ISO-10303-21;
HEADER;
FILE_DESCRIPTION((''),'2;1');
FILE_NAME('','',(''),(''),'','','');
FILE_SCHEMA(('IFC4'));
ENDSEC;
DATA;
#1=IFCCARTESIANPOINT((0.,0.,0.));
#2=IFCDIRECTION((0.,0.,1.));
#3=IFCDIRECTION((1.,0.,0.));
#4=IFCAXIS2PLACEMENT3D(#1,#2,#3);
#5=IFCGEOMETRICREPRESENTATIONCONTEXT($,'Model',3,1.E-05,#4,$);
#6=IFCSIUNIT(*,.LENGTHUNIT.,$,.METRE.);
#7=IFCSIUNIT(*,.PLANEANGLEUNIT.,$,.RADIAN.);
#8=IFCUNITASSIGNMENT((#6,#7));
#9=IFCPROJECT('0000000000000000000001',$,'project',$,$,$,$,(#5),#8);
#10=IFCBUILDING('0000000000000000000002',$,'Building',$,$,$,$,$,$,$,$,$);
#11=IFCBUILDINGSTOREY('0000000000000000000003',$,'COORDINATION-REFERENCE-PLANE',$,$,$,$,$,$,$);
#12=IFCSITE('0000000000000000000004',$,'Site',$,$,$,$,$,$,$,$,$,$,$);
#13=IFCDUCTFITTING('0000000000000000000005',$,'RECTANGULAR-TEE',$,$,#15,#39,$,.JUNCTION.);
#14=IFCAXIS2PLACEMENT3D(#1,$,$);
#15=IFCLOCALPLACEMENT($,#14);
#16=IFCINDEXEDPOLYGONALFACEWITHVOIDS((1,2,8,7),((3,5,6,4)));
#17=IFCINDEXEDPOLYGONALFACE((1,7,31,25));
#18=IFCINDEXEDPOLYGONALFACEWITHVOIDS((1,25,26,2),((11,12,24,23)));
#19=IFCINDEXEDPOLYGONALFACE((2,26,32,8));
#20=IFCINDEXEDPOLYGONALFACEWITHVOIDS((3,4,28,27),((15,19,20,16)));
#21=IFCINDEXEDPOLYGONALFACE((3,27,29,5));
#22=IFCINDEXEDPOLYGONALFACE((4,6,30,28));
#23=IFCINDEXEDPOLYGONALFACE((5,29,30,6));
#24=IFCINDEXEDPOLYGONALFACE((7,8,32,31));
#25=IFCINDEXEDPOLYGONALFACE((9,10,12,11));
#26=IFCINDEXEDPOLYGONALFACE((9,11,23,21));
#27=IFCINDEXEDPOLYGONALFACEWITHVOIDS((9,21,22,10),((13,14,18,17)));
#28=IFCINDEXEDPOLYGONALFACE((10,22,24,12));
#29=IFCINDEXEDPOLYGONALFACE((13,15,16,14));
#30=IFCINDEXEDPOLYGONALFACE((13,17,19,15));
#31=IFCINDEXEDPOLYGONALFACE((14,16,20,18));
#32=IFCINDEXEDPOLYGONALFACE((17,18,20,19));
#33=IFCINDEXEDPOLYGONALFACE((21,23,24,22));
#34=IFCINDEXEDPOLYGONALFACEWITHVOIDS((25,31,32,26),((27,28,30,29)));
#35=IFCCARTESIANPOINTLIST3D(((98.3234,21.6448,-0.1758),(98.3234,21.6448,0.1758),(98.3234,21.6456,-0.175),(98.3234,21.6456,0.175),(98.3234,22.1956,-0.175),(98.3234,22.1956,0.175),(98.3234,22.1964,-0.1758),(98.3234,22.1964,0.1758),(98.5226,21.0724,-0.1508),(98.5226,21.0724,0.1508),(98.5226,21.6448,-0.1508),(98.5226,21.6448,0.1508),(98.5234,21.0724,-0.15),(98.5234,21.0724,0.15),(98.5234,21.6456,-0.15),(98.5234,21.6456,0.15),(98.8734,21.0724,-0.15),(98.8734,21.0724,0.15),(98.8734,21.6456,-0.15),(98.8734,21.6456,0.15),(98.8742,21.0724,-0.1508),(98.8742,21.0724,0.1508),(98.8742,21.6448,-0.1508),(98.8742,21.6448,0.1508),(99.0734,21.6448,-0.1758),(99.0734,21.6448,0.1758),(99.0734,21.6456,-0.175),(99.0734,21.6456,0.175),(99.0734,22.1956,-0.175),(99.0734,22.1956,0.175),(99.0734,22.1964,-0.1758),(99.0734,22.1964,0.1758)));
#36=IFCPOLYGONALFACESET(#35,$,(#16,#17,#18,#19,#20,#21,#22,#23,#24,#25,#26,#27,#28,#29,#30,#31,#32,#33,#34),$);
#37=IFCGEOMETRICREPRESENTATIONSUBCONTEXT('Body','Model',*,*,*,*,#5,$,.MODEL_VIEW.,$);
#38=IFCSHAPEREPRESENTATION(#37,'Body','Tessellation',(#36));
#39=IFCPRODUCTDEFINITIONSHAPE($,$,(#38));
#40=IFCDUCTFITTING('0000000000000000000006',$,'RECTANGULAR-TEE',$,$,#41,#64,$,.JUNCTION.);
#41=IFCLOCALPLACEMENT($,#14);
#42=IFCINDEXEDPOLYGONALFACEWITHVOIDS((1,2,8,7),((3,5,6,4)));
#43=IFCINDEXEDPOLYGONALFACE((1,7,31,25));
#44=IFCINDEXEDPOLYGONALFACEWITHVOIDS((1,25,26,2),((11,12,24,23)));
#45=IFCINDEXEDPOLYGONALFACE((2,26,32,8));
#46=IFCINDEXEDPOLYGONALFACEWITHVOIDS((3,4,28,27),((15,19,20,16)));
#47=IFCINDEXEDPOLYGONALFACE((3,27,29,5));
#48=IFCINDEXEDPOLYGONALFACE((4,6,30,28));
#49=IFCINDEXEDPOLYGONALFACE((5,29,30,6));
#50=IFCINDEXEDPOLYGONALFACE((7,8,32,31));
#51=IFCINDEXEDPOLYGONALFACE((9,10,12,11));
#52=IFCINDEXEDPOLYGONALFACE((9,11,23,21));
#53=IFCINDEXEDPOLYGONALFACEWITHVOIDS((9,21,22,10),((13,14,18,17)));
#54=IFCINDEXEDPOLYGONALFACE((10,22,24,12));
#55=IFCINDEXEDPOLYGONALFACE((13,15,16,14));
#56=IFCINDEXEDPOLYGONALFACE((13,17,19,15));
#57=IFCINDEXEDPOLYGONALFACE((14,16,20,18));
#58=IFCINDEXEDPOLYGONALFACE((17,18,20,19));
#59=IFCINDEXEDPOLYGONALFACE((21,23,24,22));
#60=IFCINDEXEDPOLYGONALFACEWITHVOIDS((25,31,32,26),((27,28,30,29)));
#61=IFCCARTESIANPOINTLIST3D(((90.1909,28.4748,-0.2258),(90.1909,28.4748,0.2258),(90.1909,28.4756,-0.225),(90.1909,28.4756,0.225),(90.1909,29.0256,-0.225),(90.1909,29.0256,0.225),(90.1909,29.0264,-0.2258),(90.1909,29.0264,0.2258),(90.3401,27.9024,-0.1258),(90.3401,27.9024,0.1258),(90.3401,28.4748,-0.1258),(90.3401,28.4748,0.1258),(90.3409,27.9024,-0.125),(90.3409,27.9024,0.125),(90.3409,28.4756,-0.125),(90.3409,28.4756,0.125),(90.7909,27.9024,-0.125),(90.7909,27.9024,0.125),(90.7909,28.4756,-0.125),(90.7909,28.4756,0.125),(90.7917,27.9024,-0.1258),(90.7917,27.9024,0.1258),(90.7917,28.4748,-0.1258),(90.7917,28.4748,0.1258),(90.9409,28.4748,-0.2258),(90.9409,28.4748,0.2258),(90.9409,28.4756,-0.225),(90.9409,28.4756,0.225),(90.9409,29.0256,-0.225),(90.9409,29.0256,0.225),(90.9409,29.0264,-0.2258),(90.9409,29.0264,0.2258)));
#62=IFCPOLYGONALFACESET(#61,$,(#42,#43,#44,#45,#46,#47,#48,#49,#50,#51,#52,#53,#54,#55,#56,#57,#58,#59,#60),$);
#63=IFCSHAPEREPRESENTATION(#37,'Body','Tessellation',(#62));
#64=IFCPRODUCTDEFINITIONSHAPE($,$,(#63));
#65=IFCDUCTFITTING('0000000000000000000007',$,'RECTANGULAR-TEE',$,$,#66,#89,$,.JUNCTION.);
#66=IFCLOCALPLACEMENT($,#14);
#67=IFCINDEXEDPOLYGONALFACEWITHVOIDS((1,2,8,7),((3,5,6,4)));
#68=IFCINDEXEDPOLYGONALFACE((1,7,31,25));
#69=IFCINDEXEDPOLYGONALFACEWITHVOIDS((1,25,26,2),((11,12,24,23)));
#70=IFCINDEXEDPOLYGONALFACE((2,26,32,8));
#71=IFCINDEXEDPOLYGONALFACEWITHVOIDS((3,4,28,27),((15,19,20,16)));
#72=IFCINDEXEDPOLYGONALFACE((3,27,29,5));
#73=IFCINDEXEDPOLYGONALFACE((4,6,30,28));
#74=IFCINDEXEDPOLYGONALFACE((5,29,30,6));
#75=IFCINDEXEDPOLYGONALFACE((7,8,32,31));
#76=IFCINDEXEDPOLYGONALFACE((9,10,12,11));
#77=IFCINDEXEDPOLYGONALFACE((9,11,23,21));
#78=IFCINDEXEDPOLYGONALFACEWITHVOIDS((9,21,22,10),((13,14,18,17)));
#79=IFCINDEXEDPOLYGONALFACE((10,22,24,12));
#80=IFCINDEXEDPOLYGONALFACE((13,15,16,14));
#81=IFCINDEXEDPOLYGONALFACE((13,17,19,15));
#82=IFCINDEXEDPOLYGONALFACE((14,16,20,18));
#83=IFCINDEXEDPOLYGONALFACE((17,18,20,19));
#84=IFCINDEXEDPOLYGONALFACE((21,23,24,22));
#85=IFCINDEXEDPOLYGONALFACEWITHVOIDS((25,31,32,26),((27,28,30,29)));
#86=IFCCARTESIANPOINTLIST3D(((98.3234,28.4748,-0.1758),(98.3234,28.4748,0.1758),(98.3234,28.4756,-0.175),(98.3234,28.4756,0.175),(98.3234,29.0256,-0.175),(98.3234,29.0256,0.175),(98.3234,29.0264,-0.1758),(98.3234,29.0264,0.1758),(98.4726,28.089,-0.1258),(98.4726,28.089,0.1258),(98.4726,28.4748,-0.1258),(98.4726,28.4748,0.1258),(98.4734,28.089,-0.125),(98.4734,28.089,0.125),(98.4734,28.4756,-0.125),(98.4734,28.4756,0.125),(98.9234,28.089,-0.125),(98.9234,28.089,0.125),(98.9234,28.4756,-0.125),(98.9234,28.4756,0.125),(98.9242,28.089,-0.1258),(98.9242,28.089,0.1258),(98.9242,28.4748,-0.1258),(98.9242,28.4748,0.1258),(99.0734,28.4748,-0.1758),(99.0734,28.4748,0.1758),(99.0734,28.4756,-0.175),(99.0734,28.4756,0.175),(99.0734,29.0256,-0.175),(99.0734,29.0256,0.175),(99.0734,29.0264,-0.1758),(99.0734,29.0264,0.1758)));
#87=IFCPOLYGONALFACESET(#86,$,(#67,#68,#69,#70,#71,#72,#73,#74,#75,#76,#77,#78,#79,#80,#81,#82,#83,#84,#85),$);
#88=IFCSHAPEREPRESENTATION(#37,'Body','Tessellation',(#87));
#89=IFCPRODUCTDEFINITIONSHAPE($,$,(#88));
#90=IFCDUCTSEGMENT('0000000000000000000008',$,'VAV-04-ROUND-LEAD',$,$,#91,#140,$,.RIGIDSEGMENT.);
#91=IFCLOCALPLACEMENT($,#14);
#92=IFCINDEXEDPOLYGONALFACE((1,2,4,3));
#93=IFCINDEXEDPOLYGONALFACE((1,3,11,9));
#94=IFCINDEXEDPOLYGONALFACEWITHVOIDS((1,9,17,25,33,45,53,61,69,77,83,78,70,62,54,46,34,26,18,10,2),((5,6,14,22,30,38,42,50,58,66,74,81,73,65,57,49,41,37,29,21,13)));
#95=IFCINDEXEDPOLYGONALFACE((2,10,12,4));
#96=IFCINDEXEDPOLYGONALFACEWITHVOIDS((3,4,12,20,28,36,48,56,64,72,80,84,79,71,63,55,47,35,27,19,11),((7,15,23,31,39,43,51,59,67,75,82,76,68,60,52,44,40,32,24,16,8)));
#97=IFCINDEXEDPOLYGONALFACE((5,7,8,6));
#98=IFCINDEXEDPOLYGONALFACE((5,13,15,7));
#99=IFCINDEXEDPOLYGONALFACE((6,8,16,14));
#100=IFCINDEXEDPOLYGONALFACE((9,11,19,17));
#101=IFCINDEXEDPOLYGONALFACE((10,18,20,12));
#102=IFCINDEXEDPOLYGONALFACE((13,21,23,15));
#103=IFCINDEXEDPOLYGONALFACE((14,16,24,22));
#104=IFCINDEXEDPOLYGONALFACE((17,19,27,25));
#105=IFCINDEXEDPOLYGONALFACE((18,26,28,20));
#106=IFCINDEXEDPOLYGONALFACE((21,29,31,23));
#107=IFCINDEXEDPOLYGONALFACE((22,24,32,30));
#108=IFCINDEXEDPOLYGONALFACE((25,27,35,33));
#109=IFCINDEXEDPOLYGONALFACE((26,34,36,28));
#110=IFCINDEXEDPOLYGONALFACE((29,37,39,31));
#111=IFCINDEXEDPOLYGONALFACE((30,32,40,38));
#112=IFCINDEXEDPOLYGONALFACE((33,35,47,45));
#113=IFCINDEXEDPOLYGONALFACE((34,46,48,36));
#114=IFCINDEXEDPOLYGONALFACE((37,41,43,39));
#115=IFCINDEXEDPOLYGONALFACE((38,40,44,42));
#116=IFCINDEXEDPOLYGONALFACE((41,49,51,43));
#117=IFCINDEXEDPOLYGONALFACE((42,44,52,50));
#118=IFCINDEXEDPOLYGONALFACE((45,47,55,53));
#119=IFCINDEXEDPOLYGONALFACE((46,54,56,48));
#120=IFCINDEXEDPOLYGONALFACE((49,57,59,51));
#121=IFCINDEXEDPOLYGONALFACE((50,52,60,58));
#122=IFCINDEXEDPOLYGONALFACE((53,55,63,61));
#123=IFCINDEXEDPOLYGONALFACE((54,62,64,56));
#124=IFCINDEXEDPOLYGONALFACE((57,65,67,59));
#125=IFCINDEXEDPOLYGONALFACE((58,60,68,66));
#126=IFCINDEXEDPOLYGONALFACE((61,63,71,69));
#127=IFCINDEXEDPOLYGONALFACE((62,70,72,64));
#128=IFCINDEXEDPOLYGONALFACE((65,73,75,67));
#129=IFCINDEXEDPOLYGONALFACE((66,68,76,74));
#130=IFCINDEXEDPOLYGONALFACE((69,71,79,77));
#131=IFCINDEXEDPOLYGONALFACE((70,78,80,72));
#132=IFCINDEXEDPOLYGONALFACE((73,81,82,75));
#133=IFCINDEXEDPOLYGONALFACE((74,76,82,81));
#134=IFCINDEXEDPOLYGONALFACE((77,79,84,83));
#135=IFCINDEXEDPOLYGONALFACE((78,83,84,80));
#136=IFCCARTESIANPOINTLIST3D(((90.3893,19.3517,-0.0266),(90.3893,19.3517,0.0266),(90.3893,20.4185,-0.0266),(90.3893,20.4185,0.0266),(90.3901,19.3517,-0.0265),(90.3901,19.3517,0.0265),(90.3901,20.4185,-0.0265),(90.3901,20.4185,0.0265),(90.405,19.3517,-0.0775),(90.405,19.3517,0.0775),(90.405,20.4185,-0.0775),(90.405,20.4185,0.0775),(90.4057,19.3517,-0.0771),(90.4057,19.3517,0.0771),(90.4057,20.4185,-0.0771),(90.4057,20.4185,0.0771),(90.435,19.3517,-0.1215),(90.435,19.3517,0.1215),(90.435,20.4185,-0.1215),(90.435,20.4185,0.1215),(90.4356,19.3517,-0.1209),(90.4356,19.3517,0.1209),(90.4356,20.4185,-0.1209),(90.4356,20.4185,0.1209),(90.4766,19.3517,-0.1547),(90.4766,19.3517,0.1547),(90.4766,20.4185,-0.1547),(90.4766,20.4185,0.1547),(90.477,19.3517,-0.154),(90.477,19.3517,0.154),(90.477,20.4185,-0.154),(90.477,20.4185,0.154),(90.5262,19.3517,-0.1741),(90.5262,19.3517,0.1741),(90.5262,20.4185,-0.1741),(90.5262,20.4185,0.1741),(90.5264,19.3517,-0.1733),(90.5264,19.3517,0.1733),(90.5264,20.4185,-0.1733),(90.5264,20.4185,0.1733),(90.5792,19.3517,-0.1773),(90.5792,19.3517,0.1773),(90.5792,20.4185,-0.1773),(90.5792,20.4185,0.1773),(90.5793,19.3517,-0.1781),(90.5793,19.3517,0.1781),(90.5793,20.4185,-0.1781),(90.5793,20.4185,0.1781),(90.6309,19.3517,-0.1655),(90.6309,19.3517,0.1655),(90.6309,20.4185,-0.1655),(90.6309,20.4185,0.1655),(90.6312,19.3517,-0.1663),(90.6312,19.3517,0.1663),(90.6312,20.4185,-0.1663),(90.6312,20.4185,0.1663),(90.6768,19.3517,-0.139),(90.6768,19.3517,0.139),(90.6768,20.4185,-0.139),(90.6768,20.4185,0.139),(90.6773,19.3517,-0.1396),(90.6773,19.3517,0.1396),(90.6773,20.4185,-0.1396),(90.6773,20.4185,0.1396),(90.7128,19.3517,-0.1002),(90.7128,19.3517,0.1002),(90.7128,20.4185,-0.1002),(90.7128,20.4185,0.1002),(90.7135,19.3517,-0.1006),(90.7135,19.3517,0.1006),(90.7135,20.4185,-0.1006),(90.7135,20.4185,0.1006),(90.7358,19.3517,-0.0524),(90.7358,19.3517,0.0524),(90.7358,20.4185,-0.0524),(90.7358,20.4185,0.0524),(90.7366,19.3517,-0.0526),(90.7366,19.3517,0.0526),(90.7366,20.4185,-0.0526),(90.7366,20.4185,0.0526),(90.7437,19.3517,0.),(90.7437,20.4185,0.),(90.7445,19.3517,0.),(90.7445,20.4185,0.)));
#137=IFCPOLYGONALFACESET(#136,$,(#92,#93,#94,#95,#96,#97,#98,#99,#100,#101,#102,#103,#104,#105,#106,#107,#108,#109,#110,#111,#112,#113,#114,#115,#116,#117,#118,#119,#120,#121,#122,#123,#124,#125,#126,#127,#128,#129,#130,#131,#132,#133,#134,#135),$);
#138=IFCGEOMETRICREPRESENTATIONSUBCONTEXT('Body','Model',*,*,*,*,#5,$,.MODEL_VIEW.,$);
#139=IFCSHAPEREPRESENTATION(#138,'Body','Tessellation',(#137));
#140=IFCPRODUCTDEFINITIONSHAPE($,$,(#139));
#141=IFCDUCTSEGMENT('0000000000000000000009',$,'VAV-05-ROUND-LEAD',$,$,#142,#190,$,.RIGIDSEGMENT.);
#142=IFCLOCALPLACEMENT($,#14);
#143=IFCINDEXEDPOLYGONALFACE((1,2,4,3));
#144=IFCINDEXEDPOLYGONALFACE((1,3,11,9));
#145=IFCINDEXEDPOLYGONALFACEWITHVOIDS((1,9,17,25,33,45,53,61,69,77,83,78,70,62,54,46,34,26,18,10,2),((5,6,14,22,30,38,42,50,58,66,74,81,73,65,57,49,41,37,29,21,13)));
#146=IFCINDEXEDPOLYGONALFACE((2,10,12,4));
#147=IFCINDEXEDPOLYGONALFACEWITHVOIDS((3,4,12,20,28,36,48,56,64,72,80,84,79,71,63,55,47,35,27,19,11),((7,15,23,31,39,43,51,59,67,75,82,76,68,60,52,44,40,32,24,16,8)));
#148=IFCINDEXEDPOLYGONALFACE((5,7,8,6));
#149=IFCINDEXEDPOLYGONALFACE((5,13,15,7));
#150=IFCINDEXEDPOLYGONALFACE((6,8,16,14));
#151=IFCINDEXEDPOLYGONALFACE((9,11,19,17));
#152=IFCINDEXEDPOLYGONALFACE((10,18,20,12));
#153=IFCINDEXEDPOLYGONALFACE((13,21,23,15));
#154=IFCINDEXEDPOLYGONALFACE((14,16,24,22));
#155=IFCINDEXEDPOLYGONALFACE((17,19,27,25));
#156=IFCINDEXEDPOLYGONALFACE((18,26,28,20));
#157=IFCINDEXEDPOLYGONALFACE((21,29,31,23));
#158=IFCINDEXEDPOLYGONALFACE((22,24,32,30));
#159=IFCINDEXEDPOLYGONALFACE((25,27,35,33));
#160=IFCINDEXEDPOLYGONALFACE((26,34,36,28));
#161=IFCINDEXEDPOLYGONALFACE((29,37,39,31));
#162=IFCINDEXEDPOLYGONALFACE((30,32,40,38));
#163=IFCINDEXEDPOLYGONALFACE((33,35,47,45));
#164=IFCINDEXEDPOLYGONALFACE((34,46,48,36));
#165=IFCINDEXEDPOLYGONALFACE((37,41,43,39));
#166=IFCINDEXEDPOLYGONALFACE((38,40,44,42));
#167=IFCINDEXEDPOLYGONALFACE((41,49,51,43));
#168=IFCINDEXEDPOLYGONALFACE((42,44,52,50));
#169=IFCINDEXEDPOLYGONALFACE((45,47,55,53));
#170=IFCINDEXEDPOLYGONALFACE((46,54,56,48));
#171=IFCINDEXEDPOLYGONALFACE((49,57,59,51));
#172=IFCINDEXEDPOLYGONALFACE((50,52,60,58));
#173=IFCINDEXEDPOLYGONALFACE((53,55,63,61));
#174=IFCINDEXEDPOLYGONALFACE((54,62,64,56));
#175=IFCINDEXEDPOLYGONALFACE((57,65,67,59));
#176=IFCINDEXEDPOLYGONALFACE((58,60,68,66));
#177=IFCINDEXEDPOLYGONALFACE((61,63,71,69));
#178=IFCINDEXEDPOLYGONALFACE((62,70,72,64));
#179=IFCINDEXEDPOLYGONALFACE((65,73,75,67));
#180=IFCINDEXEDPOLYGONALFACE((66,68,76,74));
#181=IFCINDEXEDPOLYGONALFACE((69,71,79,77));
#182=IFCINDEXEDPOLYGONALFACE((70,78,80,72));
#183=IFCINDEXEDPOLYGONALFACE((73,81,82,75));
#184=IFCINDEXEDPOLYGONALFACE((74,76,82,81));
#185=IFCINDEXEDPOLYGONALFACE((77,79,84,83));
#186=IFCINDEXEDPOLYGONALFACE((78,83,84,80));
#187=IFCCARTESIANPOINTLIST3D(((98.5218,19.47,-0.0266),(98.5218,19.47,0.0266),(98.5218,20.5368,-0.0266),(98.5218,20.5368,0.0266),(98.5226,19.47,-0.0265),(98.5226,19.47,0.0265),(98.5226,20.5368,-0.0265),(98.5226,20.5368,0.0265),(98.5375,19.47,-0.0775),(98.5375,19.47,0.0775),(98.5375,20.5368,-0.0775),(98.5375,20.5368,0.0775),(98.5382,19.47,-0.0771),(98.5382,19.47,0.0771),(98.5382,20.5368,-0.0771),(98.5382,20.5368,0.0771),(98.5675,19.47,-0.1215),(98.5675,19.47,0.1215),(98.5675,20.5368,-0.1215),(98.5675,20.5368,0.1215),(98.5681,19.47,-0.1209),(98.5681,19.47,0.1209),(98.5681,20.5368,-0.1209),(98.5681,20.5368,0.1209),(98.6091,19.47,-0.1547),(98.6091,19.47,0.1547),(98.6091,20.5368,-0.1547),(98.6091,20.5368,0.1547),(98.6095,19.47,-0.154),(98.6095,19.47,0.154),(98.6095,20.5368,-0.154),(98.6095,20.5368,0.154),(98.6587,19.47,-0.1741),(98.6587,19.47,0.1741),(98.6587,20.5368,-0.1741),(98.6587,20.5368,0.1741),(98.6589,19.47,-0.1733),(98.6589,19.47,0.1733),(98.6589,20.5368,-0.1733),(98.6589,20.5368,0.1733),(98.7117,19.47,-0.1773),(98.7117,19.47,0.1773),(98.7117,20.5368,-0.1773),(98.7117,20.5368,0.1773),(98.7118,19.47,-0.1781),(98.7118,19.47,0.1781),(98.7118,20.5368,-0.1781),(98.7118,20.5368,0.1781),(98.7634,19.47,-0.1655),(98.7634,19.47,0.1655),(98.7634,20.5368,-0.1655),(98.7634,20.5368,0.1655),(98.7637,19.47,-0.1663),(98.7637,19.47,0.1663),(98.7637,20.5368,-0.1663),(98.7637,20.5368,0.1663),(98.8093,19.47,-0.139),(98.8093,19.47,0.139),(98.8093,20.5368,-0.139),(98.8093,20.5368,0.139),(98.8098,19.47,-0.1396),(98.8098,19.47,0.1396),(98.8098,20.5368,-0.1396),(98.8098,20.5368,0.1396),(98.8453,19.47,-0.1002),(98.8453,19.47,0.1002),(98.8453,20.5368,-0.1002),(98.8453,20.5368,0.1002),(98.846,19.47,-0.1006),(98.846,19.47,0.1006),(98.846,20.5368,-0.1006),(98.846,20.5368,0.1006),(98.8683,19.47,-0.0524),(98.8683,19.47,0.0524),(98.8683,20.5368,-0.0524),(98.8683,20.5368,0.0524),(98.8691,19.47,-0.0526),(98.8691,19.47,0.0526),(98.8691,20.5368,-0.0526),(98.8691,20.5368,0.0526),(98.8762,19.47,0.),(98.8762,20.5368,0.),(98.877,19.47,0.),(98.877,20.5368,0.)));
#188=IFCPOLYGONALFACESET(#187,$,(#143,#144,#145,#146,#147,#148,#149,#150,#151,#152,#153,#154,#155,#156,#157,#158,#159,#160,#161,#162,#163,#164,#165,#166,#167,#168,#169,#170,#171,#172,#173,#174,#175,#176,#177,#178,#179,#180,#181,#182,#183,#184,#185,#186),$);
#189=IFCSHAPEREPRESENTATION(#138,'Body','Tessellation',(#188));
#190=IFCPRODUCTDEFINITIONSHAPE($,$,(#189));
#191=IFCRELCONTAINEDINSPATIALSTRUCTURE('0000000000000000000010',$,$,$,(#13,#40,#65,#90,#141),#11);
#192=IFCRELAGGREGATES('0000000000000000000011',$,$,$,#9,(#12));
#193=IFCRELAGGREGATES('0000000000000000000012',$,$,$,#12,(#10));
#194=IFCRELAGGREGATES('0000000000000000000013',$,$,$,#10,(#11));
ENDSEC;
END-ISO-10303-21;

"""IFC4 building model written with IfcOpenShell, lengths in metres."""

from ifc_helpers import new_model, si_unit, frame, origin, origin_with_axes, place, context, subcontext, project, spatial, rectangle, hollow_circle, extrude, boolean, element, save


model = new_model("IFC4")

# Units and contexts
model_context = context("Model", 3, precision=1e-05, world=origin_with_axes())
body_context_1 = subcontext(model_context, "Body", "Model", "MODEL_VIEW")
body_context_2 = subcontext(model_context, "Body", "Model", "MODEL_VIEW")
ifc_project = project(units=[si_unit("LENGTHUNIT", "METRE"), si_unit("PLANEANGLEUNIT", "RADIAN")], contexts=[model_context])

# Site, building, storey
site = spatial("IfcSite", under=ifc_project, Name="Site")
building = spatial("IfcBuilding", under=site, Name="Building")
storey = spatial("IfcBuildingStorey", under=building, Name="COORDINATION-REFERENCE-PLANE")

# Duct fittings
duct_fitting_1_placement = place(None, frame((98.6984, 21.9206, 0.0), z_axis=(1.0, 0.0, 0.0), x_axis=(0.0, -1.0, 0.0)))
solid_1 = boolean("UNION", extrude(rectangle(XDim=0.55, YDim=0.35), frame((0.0, 0.0, -0.375), z_axis=(0.0, 0.0, 1.0), x_axis=(1.0, 0.0, 0.0)), (0.0, 0.0, 1.0), 0.75), extrude(rectangle(XDim=0.35, YDim=0.3), frame((0.0, 0.0, 0.0), z_axis=(1.0, 0.0, 0.0), x_axis=(0.0, 0.0, -1.0)), (0.0, 0.0, 1.0), 0.8482))
element("IfcDuctFitting", 1, at=duct_fitting_1_placement, inside=storey, Name="RECTANGULAR-TEE", PredefinedType="JUNCTION", context=body_context_1, shape_type="CSG", body=[
    boolean("DIFFERENCE", boolean("UNION", extrude(rectangle(XDim=0.5516, YDim=0.3516), frame((0.0, 0.0, -0.375), z_axis=(0.0, 0.0, 1.0), x_axis=(1.0, 0.0, 0.0)), (0.0, 0.0, 1.0), 0.75), extrude(rectangle(XDim=0.3516, YDim=0.3016), frame((0.0, 0.0, 0.0), z_axis=(1.0, 0.0, 0.0), x_axis=(0.0, 0.0, -1.0)), (0.0, 0.0, 1.0), 0.8482)), solid_1),
])
duct_fitting_2_placement = place(None, frame((90.5659, 28.7506, 0.0), z_axis=(1.0, 0.0, 0.0), x_axis=(0.0, -1.0, 0.0)))
solid_2 = boolean("UNION", extrude(rectangle(XDim=0.55, YDim=0.45), frame((0.0, 0.0, -0.375), z_axis=(0.0, 0.0, 1.0), x_axis=(1.0, 0.0, 0.0)), (0.0, 0.0, 1.0), 0.75), extrude(rectangle(XDim=0.45, YDim=0.25), frame((0.0, 0.0, 0.0), z_axis=(1.0, 0.0, 0.0), x_axis=(0.0, 0.0, -1.0)), (0.0, 0.0, 1.0), 0.8482))
element("IfcDuctFitting", 2, at=duct_fitting_2_placement, inside=storey, Name="RECTANGULAR-TEE", PredefinedType="JUNCTION", context=body_context_1, shape_type="CSG", body=[
    boolean("DIFFERENCE", boolean("UNION", extrude(rectangle(XDim=0.5516, YDim=0.4516), frame((0.0, 0.0, -0.375), z_axis=(0.0, 0.0, 1.0), x_axis=(1.0, 0.0, 0.0)), (0.0, 0.0, 1.0), 0.75), extrude(rectangle(XDim=0.4516, YDim=0.2516), frame((0.0, 0.0, 0.0), z_axis=(1.0, 0.0, 0.0), x_axis=(0.0, 0.0, -1.0)), (0.0, 0.0, 1.0), 0.8482)), solid_2),
])
duct_fitting_3_placement = place(None, frame((98.6984, 28.7506, 0.0), z_axis=(1.0, 0.0, 0.0), x_axis=(0.0, -1.0, 0.0)))
solid_3 = boolean("UNION", extrude(rectangle(XDim=0.55, YDim=0.35), frame((0.0, 0.0, -0.375), z_axis=(0.0, 0.0, 1.0), x_axis=(1.0, 0.0, 0.0)), (0.0, 0.0, 1.0), 0.75), extrude(rectangle(XDim=0.45, YDim=0.25), frame((0.0, 0.0, 0.0), z_axis=(1.0, 0.0, 0.0), x_axis=(0.0, 0.0, -1.0)), (0.0, 0.0, 1.0), 0.6616))
element("IfcDuctFitting", 3, at=duct_fitting_3_placement, inside=storey, Name="RECTANGULAR-TEE", PredefinedType="JUNCTION", context=body_context_1, shape_type="CSG", body=[
    boolean("DIFFERENCE", boolean("UNION", extrude(rectangle(XDim=0.5516, YDim=0.3516), frame((0.0, 0.0, -0.375), z_axis=(0.0, 0.0, 1.0), x_axis=(1.0, 0.0, 0.0)), (0.0, 0.0, 1.0), 0.75), extrude(rectangle(XDim=0.4516, YDim=0.2516), frame((0.0, 0.0, 0.0), z_axis=(1.0, 0.0, 0.0), x_axis=(0.0, 0.0, -1.0)), (0.0, 0.0, 1.0), 0.6616)), solid_3),
])

# Duct segments
for number, where, z_axis, x_axis, name in (
    (4, (90.5659, 20.4185, 0.0), (0.0, -1.0, 0.0), (1.0, 0.0, 0.0), "VAV-04-ROUND-LEAD"),
    (5, (98.6984, 20.5368, 0.0), (0.0, -1.0, 0.0), (1.0, 0.0, 0.0), "VAV-05-ROUND-LEAD"),
):
    element("IfcDuctSegment", number, at=place(None, frame(where, z_axis=z_axis, x_axis=x_axis)), inside=storey, Name=name, PredefinedType="RIGIDSEGMENT", context=body_context_2, shape_type="SweptSolid", body=[
        extrude(hollow_circle(Radius=0.1786, WallThickness=0.0008), origin(), (0.0, 0.0, 1.0), 1.0668),
    ])

save(model, "model.ifc")
